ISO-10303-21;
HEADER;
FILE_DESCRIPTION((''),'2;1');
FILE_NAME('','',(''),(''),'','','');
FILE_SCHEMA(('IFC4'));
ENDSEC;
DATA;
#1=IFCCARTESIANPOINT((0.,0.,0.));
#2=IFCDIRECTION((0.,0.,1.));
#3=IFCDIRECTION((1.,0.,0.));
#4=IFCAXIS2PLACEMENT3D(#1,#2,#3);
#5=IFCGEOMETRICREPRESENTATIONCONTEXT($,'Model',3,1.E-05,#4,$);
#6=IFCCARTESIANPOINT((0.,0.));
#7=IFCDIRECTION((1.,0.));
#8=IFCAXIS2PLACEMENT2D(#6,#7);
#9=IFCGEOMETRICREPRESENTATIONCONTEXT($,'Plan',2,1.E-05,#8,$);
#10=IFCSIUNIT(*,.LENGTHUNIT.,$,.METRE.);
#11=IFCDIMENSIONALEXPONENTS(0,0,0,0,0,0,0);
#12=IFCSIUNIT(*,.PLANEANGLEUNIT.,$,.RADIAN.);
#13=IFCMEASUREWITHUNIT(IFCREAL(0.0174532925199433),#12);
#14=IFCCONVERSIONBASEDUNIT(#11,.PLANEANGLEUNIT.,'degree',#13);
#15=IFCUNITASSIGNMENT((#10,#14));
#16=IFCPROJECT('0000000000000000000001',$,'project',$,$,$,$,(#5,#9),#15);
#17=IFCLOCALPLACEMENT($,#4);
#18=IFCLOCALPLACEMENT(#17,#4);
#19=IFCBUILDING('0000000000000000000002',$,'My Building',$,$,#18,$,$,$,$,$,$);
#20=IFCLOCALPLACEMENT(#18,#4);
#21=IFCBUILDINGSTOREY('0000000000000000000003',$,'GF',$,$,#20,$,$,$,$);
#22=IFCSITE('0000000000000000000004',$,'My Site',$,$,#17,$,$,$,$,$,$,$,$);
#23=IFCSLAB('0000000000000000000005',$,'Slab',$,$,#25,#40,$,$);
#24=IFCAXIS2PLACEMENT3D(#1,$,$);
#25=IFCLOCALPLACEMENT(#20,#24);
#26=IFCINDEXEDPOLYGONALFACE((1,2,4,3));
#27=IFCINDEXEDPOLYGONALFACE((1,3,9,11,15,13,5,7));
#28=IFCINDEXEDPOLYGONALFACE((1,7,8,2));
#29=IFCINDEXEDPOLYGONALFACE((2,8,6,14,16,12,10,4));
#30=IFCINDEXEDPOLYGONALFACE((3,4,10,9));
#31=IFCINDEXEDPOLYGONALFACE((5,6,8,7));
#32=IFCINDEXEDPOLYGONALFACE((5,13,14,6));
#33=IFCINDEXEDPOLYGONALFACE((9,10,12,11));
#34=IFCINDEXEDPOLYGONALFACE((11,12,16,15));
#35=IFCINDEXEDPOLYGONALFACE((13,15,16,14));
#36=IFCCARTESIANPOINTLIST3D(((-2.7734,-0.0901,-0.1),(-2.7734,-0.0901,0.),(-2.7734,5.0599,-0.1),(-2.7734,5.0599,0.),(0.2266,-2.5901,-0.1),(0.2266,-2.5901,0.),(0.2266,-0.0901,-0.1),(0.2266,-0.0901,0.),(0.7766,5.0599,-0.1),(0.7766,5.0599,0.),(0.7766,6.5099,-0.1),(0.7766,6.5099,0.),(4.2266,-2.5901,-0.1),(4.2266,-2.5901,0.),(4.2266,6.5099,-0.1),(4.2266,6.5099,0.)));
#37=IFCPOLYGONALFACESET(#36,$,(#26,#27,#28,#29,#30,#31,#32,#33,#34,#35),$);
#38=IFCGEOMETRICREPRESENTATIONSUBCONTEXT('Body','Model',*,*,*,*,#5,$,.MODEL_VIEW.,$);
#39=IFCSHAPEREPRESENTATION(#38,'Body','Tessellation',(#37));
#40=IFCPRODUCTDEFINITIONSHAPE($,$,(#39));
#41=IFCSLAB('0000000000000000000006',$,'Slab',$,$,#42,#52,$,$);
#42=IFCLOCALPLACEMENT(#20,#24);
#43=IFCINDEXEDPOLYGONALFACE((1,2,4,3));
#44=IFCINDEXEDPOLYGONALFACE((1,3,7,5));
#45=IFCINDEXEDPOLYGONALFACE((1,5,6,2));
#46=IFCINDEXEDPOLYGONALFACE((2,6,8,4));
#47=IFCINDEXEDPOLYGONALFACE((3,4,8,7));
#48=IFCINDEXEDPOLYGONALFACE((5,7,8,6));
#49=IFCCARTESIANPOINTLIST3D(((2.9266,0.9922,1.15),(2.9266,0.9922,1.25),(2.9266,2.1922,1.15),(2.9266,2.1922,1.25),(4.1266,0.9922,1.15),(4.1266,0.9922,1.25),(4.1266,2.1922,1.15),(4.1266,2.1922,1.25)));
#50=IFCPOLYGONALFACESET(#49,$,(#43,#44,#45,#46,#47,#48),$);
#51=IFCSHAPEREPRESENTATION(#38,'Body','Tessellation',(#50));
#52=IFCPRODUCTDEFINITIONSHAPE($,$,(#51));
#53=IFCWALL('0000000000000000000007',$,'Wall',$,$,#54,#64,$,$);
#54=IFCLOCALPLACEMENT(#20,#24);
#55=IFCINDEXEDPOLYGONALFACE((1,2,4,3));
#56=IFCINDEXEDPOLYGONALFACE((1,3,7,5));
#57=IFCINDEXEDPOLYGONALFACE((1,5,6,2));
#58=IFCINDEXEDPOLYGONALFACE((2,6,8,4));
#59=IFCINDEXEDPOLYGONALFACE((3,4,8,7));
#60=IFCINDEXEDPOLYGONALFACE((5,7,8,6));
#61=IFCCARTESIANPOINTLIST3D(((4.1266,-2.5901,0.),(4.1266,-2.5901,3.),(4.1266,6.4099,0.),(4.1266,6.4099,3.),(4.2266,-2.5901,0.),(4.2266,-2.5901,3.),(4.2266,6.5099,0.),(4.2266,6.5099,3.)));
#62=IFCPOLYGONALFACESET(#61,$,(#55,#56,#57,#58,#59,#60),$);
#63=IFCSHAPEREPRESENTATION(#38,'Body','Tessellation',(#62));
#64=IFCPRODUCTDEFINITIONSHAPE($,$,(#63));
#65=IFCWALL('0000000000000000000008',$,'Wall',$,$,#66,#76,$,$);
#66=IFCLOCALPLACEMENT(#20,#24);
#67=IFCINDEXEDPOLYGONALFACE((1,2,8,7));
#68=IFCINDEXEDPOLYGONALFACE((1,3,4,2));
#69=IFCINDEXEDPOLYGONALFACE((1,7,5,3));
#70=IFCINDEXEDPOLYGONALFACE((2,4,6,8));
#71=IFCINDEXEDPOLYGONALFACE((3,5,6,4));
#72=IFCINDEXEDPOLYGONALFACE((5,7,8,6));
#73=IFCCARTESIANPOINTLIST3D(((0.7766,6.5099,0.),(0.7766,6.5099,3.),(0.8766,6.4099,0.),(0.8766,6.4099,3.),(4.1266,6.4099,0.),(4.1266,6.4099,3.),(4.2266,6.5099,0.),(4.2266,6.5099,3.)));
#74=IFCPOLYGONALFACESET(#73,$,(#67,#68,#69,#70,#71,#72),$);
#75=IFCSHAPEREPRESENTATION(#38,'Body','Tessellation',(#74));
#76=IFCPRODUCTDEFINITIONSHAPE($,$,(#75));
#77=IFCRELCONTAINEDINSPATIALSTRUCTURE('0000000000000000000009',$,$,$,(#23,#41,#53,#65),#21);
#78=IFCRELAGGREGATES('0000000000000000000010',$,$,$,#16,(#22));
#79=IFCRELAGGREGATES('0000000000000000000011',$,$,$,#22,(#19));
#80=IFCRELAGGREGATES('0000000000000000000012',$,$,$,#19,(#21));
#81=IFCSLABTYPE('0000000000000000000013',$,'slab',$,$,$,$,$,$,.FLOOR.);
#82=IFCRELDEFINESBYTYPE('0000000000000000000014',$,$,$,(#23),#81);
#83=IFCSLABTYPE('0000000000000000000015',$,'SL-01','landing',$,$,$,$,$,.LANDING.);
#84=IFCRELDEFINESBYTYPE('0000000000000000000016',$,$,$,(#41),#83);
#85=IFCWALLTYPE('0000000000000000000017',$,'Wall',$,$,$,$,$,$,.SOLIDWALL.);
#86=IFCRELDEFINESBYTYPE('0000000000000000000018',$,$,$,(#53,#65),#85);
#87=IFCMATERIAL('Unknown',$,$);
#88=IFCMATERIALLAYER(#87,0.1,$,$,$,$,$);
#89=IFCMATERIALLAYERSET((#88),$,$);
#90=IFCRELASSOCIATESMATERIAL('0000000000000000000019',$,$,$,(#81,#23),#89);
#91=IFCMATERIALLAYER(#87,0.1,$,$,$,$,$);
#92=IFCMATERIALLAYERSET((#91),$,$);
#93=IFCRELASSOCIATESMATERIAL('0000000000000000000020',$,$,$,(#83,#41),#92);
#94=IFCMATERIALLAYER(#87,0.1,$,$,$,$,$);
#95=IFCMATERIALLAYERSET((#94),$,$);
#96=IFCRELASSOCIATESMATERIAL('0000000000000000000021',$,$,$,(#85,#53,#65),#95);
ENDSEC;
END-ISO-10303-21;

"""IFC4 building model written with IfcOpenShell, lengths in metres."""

from ifc_helpers import new_model, entity, si_unit, converted_unit, frame, origin_with_axes, origin_2d_with_axis, place, context, subcontext, project, spatial, line, indexed_curve, outline, extrude, material, layer, layer_set, layer_usage, type_object, element, save


model = new_model("IFC4")

# Units and contexts
model_context = context("Model", 3, precision=1e-05, world=origin_with_axes())
plan_context = context("Plan", 2, precision=1e-05, world=origin_2d_with_axis())
body_context_1 = subcontext(model_context, "Body", "Model", "MODEL_VIEW")
ifc_project = project(units=[si_unit("LENGTHUNIT", "METRE"), converted_unit("PLANEANGLEUNIT", "degree", entity("IfcReal", 0.0174532925199433), si_unit("PLANEANGLEUNIT", "RADIAN"), dimensions=[0, 0, 0, 0, 0, 0, 0])], contexts=[model_context, plan_context])

# Site, building, storey
site_placement = place(None, origin_with_axes())
site = spatial("IfcSite", under=ifc_project, at=site_placement, Name="My Site")
building_placement = place(site_placement, origin_with_axes())
building = spatial("IfcBuilding", under=site, at=building_placement, Name="My Building")
storey_placement = place(building_placement, origin_with_axes())
storey = spatial("IfcBuildingStorey", under=building, at=storey_placement, Name="GF")

# Slabs
ifc_material = material(Name="Unknown")
ifc_layer_1 = layer(ifc_material, 0.1)
ifc_layer_set_1 = layer_set([ifc_layer_1])
ifc_layer_usage_1 = layer_usage(ifc_layer_set_1, "AXIS3", "POSITIVE", -0.1)
slab_type_1 = type_object("IfcSlabType", Name="slab", PredefinedType="FLOOR", material=ifc_layer_set_1)
slab_1_placement = place(storey_placement, frame((4.2266, -2.5901, 0.0), z_axis=(0.0, 0.0, 1.0), x_axis=(1.0, 0.0, 0.0)))
element("IfcSlab", 1, at=slab_1_placement, inside=storey, type_object=slab_type_1, material=ifc_layer_usage_1, Name="Slab", context=body_context_1, shape_type="SweptSolid", body=[
    extrude(outline(indexed_curve([(0.0, 0.0), (0.0, 9.1), (-3.45, 9.1), (-3.45, 7.65), (-7.0, 7.65), (-7.0, 2.5), (-4.0, 2.5), (-4.0, 0.0), (0.0, 0.0)])), frame((0.0, 0.0, -0.1), z_axis=(0.0, 0.0, 1.0), x_axis=(1.0, 0.0, 0.0)), (0.0, 0.0, 1.0), 0.1),
])
ifc_layer_2 = layer(ifc_material, 0.1)
ifc_layer_set_2 = layer_set([ifc_layer_2])
ifc_layer_usage_2 = layer_usage(ifc_layer_set_2, "AXIS3", "POSITIVE", -0.1)
slab_type_2 = type_object("IfcSlabType", Name="SL-01", Description="landing", PredefinedType="LANDING", material=ifc_layer_set_2)
slab_2_placement = place(storey_placement, frame((2.9266, 2.1922, 1.25), z_axis=(0.0, 0.0, 1.0), x_axis=(1.0, 0.0, 0.0)))
element("IfcSlab", 2, at=slab_2_placement, inside=storey, type_object=slab_type_2, material=ifc_layer_usage_2, Name="Slab", context=body_context_1, shape_type="SweptSolid", body=[
    extrude(outline(indexed_curve([(0.0, 0.0), (0.0, -1.2), (1.2, -1.2), (1.2, 0.0), (0.0, 0.0)])), frame((0.0, 0.0, -0.1), z_axis=(0.0, 0.0, 1.0), x_axis=(1.0, 0.0, 0.0)), (0.0, 0.0, 1.0), 0.1),
])

# Shared definitions
ifc_layer_3 = layer(ifc_material, 0.1)
ifc_layer_set_3 = layer_set([ifc_layer_3])
wall_type = type_object("IfcWallType", Name="Wall", PredefinedType="SOLIDWALL", material=ifc_layer_set_3)

# Walls
ifc_layer_usage_3 = layer_usage(ifc_layer_set_3, "AXIS2", "POSITIVE", 0.0)
wall_1_placement = place(storey_placement, frame((4.2266, -2.5901, 0.0), z_axis=(0.0, 0.0, 1.0), x_axis=(0.0, 1.0, 0.0)))
element("IfcWall", 3, at=wall_1_placement, inside=storey, type_object=wall_type, material=ifc_layer_usage_3, Name="Wall", context=body_context_1, shape_type="SweptSolid", body=[
    extrude(outline(indexed_curve([(0.0, 0.0), (0.0, 0.1), (9.0, 0.1), (9.1, 0.0)], segments=[line(1, 2, 3, 4, 1)])), origin_with_axes(), (0.0, 0.0, 1.0), 3.0),
])
ifc_layer_usage_4 = layer_usage(ifc_layer_set_3, "AXIS2", "POSITIVE", 0.0)
wall_2_placement = place(storey_placement, frame((4.2266, 6.5099, 0.0), z_axis=(0.0, 0.0, 1.0), x_axis=(-1.0, 0.0, 0.0)))
element("IfcWall", 4, at=wall_2_placement, inside=storey, type_object=wall_type, material=ifc_layer_usage_4, Name="Wall", context=body_context_1, shape_type="SweptSolid", body=[
    extrude(outline(indexed_curve([(0.0, 0.0), (0.1, 0.1), (3.35, 0.1), (3.45, 0.0)], segments=[line(1, 2, 3, 4, 1)])), origin_with_axes(), (0.0, 0.0, 1.0), 3.0),
])

save(model, "model.ifc")
